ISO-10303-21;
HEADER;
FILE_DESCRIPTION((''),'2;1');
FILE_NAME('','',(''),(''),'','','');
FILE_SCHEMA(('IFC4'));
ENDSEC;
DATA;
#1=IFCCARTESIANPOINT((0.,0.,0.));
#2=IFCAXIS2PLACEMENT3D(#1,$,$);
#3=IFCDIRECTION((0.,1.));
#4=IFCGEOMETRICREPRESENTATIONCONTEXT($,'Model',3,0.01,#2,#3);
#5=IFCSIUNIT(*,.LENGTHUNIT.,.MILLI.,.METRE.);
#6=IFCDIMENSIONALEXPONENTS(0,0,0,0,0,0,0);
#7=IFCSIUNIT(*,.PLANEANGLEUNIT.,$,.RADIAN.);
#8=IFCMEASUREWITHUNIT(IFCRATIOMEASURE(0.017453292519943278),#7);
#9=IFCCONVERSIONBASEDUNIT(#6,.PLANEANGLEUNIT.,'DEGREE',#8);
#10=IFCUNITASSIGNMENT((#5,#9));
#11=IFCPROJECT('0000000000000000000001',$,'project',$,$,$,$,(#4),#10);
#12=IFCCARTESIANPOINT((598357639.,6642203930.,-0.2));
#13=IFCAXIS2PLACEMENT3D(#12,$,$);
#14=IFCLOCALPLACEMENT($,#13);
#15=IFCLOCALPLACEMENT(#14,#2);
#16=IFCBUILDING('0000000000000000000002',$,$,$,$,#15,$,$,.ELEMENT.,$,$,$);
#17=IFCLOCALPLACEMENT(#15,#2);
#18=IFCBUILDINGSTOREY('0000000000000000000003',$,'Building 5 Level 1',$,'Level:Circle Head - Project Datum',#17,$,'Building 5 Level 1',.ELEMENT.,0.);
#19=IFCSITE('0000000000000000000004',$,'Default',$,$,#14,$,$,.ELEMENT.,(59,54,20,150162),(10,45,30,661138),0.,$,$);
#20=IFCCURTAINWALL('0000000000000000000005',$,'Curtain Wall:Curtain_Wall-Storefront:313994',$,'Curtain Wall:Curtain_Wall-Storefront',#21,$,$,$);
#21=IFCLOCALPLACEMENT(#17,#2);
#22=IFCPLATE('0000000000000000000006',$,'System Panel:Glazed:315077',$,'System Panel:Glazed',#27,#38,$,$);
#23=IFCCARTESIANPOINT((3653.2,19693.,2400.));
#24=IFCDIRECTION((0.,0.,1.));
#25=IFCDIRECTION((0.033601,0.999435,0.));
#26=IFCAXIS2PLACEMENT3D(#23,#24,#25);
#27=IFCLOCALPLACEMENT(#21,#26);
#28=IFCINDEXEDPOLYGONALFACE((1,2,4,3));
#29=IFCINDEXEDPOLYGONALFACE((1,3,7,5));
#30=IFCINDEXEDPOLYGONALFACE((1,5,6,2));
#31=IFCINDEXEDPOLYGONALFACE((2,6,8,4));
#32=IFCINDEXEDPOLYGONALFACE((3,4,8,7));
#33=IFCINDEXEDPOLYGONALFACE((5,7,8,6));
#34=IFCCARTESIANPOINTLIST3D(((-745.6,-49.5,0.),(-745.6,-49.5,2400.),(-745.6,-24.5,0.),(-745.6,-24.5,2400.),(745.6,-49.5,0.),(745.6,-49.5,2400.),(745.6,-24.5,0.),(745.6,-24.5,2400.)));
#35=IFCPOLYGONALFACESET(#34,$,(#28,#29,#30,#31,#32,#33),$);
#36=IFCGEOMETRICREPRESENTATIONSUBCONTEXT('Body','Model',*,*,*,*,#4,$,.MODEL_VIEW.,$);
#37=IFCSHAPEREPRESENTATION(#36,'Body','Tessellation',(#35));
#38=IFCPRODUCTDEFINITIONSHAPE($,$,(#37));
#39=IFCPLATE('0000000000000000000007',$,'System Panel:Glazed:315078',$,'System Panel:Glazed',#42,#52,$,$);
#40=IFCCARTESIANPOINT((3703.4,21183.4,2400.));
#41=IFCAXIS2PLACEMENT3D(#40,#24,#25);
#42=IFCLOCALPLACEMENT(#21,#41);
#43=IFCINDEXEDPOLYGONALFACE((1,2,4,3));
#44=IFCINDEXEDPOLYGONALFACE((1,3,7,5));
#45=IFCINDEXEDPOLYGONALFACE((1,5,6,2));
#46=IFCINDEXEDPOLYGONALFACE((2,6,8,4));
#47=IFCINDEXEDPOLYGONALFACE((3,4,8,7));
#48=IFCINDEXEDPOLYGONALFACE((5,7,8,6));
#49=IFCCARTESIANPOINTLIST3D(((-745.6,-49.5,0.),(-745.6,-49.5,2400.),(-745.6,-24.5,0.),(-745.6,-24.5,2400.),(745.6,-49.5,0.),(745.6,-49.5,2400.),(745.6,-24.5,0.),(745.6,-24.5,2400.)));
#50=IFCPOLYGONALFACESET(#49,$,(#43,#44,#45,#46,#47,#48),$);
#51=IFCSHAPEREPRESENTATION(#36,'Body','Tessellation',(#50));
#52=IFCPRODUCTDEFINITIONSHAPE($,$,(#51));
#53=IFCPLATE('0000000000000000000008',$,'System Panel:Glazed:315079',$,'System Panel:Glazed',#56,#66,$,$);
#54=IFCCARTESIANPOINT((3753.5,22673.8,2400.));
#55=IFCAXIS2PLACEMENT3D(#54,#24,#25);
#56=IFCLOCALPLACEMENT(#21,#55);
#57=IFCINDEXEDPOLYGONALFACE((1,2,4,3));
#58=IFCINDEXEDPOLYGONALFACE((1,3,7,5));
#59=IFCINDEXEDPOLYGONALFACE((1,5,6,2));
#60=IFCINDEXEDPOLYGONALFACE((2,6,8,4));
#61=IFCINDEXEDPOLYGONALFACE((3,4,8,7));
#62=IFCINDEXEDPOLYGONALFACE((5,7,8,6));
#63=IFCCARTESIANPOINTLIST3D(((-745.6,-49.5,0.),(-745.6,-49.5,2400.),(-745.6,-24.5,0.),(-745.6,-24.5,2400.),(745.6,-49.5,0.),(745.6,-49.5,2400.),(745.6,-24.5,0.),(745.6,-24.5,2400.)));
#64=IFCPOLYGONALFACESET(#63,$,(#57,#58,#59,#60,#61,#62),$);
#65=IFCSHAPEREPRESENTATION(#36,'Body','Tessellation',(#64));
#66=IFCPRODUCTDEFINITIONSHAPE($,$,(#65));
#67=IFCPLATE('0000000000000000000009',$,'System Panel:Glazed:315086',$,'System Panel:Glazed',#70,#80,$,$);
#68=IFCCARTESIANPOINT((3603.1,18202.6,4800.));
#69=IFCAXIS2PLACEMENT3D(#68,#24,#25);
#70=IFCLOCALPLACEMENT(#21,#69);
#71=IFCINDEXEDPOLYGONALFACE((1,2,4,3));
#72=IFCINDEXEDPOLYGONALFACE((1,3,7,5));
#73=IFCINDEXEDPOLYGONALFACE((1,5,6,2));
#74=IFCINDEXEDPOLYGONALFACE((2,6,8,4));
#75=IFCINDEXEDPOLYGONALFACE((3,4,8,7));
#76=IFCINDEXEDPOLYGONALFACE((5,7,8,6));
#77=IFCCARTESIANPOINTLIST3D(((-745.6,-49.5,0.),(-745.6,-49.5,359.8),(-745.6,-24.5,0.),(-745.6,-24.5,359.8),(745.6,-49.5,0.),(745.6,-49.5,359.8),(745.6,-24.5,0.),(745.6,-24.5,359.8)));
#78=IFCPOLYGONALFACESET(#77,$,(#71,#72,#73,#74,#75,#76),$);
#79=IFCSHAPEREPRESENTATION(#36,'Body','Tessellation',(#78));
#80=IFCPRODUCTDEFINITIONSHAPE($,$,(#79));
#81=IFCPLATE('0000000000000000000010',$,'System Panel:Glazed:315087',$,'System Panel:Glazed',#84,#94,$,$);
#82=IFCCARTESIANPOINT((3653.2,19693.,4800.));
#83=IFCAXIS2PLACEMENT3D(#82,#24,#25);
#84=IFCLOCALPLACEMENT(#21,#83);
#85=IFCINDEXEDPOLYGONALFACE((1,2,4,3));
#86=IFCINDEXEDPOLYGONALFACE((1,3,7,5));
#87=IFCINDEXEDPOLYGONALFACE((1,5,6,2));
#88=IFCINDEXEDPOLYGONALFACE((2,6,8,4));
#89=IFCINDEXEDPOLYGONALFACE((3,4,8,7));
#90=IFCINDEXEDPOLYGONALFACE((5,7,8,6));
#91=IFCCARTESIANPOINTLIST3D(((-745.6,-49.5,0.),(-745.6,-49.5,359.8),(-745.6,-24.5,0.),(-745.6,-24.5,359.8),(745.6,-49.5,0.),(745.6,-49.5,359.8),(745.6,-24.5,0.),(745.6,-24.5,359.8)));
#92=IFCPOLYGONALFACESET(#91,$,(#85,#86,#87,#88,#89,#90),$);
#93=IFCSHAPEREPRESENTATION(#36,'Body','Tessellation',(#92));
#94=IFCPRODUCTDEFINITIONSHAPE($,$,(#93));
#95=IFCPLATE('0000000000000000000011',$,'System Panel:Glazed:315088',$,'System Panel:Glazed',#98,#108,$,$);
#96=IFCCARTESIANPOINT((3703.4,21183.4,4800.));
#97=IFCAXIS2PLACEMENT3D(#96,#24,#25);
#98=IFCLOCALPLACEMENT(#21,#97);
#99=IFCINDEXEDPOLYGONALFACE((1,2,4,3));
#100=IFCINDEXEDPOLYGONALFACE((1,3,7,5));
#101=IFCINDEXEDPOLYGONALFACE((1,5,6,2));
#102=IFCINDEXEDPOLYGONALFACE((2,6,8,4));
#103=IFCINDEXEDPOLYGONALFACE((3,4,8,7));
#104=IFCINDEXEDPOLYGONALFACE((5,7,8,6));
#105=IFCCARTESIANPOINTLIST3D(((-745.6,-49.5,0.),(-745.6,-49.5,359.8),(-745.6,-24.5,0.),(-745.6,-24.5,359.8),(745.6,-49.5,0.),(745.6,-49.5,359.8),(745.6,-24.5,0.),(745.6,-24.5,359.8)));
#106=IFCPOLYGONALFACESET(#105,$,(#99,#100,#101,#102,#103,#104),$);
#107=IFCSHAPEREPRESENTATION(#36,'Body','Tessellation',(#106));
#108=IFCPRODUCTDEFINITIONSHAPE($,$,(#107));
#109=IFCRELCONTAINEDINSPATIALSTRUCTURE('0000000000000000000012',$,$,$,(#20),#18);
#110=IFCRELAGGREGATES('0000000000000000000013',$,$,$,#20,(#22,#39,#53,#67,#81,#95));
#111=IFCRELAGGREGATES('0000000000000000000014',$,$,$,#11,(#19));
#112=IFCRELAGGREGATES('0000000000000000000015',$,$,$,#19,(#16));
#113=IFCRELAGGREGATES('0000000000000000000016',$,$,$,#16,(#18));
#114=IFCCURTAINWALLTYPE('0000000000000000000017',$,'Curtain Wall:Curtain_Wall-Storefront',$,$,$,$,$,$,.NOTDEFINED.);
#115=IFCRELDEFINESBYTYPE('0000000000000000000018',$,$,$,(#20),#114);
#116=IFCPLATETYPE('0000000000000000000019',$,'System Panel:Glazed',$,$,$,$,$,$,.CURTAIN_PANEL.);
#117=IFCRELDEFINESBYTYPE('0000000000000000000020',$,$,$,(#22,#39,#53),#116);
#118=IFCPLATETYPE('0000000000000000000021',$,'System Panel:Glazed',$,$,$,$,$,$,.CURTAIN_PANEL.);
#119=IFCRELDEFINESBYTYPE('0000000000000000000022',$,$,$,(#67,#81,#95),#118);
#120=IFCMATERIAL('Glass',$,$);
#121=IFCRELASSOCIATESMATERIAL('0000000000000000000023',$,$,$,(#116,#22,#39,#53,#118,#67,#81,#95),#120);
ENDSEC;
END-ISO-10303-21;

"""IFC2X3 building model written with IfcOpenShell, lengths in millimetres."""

from ifc_helpers import new_model, entity, si_unit, converted_unit, direction, frame, frame_2d, origin, place, context, subcontext, project, spatial, rectangle, extrude, source, transform, mapped, material, type_object, type_shapes, element, aggregate, save


model = new_model("IFC2X3")

# Units and contexts
model_context = context("Model", 3, precision=0.01, world=origin(), true_north=direction((0.0, 1.0)))
body_context = subcontext(model_context, "Body", "Model", "MODEL_VIEW")
ifc_project = project(units=[si_unit("LENGTHUNIT", "METRE", prefix="MILLI"), converted_unit("PLANEANGLEUNIT", "DEGREE", entity("IfcRatioMeasure", 0.017453292519943278), si_unit("PLANEANGLEUNIT", "RADIAN"), dimensions=[0, 0, 0, 0, 0, 0, 0])], contexts=[model_context])

# Site, building, storey
site_placement = place(None, frame((598357639.0, 6642203930.0, -0.2)))
site = spatial("IfcSite", under=ifc_project, at=site_placement, Name="Default", CompositionType="ELEMENT", RefLatitude=(59, 54, 20, 150162), RefLongitude=(10, 45, 30, 661138), RefElevation=0.0)
building_placement = place(site_placement, origin())
building = spatial("IfcBuilding", under=site, at=building_placement, CompositionType="ELEMENT")
storey_placement = place(building_placement, origin())
storey = spatial("IfcBuildingStorey", under=building, at=storey_placement, Name="Building 5 Level 1", ObjectType="Level:Circle Head - Project Datum", LongName="Building 5 Level 1", CompositionType="ELEMENT", Elevation=0.0)

# Curtain wall, plates
curtain_wall_type = type_object("IfcCurtainWallType", Name="Curtain Wall:Curtain_Wall-Storefront", PredefinedType="NOTDEFINED")
ifc_material = material(Name="Glass")
curtain_wall_1_placement = place(storey_placement, origin())
curtain_wall_1 = element("IfcCurtainWall", 1, at=curtain_wall_1_placement, inside=storey, type_object=curtain_wall_type, Name="Curtain Wall:Curtain_Wall-Storefront:313994", ObjectType="Curtain Wall:Curtain_Wall-Storefront")
plate_type_1 = type_object("IfcPlateType", Name="System Panel:Glazed", PredefinedType="CURTAIN_PANEL", material=ifc_material)
shared_shape_1 = source(origin(), body_context, "Body", "SweptSolid", [
    extrude(rectangle(XDim=25.0, YDim=1491.2, at=frame_2d((0.0, 0.0), x_axis=(1.0, 0.0))), frame((0.0, -37.0, 0.0), z_axis=(0.0, 0.0, 1.0), x_axis=(0.0, 1.0, 0.0)), (0.0, 0.0, 1.0), 2400.0),
])
type_shapes(plate_type_1, [shared_shape_1])
plate_1_placement = place(curtain_wall_1_placement, frame((3653.2, 19693.0, 2400.0), z_axis=(0.0, 0.0, 1.0), x_axis=(0.033601, 0.999435, 0.0)))
plate_1 = element("IfcPlate", 2, at=plate_1_placement, type_object=plate_type_1, material=ifc_material, Name="System Panel:Glazed:315077", ObjectType="System Panel:Glazed", context=body_context, shape_type="MappedRepresentation", body=[
    mapped(shared_shape_1, transform((0.0, 0.0, 0.0), scale=1.0)),
])
plate_2_placement = place(curtain_wall_1_placement, frame((3703.4, 21183.4, 2400.0), z_axis=(0.0, 0.0, 1.0), x_axis=(0.033601, 0.999435, 0.0)))
plate_2 = element("IfcPlate", 3, at=plate_2_placement, type_object=plate_type_1, material=ifc_material, Name="System Panel:Glazed:315078", ObjectType="System Panel:Glazed", context=body_context, shape_type="MappedRepresentation", body=[
    mapped(shared_shape_1, transform((0.0, 0.0, 0.0), scale=1.0)),
])
plate_3_placement = place(curtain_wall_1_placement, frame((3753.5, 22673.8, 2400.0), z_axis=(0.0, 0.0, 1.0), x_axis=(0.033601, 0.999435, 0.0)))
plate_3 = element("IfcPlate", 4, at=plate_3_placement, type_object=plate_type_1, material=ifc_material, Name="System Panel:Glazed:315079", ObjectType="System Panel:Glazed", context=body_context, shape_type="MappedRepresentation", body=[
    mapped(shared_shape_1, transform((0.0, 0.0, 0.0), scale=1.0)),
])
plate_type_2 = type_object("IfcPlateType", Name="System Panel:Glazed", PredefinedType="CURTAIN_PANEL", material=ifc_material)
shared_shape_2 = source(origin(), body_context, "Body", "SweptSolid", [
    extrude(rectangle(XDim=25.0, YDim=1491.2, at=frame_2d((0.0, 0.0), x_axis=(1.0, 0.0))), frame((0.0, -37.0, 0.0), z_axis=(0.0, 0.0, 1.0), x_axis=(0.0, 1.0, 0.0)), (0.0, 0.0, 1.0), 359.8),
])
type_shapes(plate_type_2, [shared_shape_2])
plate_4_placement = place(curtain_wall_1_placement, frame((3603.1, 18202.6, 4800.0), z_axis=(0.0, 0.0, 1.0), x_axis=(0.033601, 0.999435, 0.0)))
plate_4 = element("IfcPlate", 5, at=plate_4_placement, type_object=plate_type_2, material=ifc_material, Name="System Panel:Glazed:315086", ObjectType="System Panel:Glazed", context=body_context, shape_type="MappedRepresentation", body=[
    mapped(shared_shape_2, transform((0.0, 0.0, 0.0), scale=1.0)),
])
plate_5_placement = place(curtain_wall_1_placement, frame((3653.2, 19693.0, 4800.0), z_axis=(0.0, 0.0, 1.0), x_axis=(0.033601, 0.999435, 0.0)))
plate_5 = element("IfcPlate", 6, at=plate_5_placement, type_object=plate_type_2, material=ifc_material, Name="System Panel:Glazed:315087", ObjectType="System Panel:Glazed", context=body_context, shape_type="MappedRepresentation", body=[
    mapped(shared_shape_2, transform((0.0, 0.0, 0.0), scale=1.0)),
])
plate_6_placement = place(curtain_wall_1_placement, frame((3703.4, 21183.4, 4800.0), z_axis=(0.0, 0.0, 1.0), x_axis=(0.033601, 0.999435, 0.0)))
plate_6 = element("IfcPlate", 7, at=plate_6_placement, type_object=plate_type_2, material=ifc_material, Name="System Panel:Glazed:315088", ObjectType="System Panel:Glazed", context=body_context, shape_type="MappedRepresentation", body=[
    mapped(shared_shape_2, transform((0.0, 0.0, 0.0), scale=1.0)),
])
aggregate(curtain_wall_1, [plate_1, plate_2, plate_3, plate_4, plate_5, plate_6])

save(model, "model.ifc")
